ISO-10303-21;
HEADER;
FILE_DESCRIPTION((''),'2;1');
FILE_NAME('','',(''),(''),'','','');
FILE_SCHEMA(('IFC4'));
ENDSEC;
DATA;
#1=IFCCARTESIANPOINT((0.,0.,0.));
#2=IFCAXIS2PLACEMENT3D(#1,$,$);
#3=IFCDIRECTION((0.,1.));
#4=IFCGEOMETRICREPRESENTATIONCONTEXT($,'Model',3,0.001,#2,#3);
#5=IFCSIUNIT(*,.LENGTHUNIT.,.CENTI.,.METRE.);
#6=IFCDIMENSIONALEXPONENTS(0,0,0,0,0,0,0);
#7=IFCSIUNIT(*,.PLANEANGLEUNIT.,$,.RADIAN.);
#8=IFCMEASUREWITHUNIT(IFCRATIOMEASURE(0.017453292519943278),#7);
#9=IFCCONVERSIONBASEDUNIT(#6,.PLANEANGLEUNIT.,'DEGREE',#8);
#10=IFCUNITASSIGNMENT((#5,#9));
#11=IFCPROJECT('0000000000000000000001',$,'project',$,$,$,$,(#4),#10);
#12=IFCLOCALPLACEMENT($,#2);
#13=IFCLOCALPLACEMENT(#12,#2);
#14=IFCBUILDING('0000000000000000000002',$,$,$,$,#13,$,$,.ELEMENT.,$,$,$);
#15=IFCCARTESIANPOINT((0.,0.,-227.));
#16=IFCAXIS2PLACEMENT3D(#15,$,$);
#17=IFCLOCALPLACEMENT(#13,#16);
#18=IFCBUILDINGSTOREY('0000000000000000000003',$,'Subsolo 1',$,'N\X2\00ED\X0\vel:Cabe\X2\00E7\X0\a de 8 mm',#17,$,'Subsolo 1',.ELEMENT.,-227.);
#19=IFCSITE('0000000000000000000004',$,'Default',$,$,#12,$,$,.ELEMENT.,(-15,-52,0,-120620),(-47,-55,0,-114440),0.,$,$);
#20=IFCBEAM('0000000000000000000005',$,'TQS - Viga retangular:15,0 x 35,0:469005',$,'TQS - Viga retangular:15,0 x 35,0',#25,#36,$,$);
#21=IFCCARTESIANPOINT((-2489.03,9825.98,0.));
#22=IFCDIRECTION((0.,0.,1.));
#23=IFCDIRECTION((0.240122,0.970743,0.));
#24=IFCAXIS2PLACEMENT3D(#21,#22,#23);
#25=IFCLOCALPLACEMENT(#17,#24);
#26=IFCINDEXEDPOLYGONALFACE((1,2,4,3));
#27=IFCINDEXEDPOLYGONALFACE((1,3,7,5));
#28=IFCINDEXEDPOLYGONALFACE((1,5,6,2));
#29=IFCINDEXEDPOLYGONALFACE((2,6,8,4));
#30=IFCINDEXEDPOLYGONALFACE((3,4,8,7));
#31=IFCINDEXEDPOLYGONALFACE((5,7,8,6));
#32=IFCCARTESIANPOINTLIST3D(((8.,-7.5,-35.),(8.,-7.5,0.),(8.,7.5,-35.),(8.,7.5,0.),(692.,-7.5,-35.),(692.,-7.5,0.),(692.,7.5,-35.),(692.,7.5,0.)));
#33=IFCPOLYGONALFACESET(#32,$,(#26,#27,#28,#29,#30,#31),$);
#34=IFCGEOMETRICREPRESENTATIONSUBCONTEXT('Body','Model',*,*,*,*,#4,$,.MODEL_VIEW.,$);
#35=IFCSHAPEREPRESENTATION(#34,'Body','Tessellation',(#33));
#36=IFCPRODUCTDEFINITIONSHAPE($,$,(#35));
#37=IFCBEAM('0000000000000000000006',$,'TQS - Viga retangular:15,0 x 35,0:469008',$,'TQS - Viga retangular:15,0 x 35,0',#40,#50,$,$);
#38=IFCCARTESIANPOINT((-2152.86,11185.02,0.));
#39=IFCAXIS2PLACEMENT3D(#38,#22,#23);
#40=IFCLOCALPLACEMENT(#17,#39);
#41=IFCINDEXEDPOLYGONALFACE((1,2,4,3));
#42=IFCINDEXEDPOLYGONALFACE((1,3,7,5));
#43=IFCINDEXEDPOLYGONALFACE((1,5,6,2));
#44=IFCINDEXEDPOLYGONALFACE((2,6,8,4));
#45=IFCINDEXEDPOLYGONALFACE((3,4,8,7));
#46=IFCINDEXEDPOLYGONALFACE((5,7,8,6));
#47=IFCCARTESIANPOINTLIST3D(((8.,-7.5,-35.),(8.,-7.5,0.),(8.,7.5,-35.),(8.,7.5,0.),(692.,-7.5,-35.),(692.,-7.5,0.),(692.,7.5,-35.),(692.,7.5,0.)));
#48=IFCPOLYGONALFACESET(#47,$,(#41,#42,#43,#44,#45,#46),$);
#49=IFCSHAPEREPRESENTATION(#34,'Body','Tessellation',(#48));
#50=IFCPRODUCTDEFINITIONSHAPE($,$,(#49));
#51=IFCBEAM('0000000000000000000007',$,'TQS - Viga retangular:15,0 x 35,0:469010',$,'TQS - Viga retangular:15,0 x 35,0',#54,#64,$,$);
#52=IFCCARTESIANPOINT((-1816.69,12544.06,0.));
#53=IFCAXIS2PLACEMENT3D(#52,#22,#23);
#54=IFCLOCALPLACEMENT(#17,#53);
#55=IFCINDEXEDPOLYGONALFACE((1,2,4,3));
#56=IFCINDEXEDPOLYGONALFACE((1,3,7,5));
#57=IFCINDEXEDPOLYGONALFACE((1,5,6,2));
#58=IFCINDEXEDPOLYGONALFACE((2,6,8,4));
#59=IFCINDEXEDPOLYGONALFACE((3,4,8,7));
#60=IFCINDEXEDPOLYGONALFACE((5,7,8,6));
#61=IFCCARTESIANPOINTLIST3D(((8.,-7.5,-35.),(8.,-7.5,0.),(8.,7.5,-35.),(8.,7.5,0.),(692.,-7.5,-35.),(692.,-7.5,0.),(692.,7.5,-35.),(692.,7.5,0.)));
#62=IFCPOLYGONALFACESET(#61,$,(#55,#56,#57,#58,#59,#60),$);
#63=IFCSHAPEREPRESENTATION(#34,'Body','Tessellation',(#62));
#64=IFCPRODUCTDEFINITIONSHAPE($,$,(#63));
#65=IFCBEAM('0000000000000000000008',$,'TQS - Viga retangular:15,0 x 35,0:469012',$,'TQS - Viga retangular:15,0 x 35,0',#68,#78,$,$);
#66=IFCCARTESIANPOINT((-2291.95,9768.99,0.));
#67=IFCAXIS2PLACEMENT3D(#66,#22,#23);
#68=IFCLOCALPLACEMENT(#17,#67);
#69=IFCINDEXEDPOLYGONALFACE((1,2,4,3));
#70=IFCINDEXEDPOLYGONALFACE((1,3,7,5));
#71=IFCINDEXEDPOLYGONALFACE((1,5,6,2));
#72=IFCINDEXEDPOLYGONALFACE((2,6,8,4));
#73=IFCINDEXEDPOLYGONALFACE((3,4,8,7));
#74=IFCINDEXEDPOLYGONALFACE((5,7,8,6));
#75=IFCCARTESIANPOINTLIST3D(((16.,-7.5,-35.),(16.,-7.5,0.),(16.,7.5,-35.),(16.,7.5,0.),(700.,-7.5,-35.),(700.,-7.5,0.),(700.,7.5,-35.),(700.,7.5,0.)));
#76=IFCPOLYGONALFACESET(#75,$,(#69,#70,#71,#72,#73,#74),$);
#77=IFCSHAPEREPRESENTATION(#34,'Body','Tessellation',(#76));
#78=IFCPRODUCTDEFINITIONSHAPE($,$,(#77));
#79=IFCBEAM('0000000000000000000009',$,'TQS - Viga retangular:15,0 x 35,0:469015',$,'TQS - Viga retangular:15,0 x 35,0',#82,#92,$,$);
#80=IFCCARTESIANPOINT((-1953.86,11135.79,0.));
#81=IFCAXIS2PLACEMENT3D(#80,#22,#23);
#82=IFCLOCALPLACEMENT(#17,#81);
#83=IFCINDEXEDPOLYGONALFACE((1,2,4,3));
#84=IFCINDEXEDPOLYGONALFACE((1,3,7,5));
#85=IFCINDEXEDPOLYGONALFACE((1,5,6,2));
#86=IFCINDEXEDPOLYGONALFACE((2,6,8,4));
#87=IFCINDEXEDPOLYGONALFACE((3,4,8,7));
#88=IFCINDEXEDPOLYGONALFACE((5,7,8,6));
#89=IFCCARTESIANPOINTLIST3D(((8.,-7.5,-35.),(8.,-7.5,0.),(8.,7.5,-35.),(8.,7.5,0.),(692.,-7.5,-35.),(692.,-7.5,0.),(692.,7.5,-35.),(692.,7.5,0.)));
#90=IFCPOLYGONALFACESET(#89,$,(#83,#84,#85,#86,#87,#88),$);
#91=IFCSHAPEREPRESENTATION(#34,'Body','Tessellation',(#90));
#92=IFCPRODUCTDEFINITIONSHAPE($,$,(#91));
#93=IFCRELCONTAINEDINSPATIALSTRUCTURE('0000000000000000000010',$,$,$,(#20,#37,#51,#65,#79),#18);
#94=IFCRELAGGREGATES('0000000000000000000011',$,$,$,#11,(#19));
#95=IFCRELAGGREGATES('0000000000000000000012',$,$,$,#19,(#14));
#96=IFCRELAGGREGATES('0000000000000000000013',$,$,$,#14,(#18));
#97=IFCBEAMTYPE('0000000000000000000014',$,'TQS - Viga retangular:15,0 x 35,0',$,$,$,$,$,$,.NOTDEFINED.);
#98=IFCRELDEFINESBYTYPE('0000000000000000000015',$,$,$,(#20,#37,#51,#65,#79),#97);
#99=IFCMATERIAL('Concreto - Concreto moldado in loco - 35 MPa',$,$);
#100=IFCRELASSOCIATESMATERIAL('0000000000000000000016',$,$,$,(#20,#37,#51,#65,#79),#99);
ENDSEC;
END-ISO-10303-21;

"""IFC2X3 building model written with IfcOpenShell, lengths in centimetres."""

from ifc_helpers import new_model, entity, si_unit, converted_unit, direction, frame, frame_2d, origin, place, context, subcontext, project, spatial, rectangle, extrude, material, type_object, element, save


model = new_model("IFC2X3")

# Units and contexts
model_context = context("Model", 3, precision=0.001, world=origin(), true_north=direction((0.0, 1.0)))
body_context = subcontext(model_context, "Body", "Model", "MODEL_VIEW")
ifc_project = project(units=[si_unit("LENGTHUNIT", "METRE", prefix="CENTI"), converted_unit("PLANEANGLEUNIT", "DEGREE", entity("IfcRatioMeasure", 0.017453292519943278), si_unit("PLANEANGLEUNIT", "RADIAN"), dimensions=[0, 0, 0, 0, 0, 0, 0])], contexts=[model_context])

# Site, building, storey
site_placement = place(None, origin())
site = spatial("IfcSite", under=ifc_project, at=site_placement, Name="Default", CompositionType="ELEMENT", RefLatitude=(-15, -52, 0, -120620), RefLongitude=(-47, -55, 0, -114440), RefElevation=0.0)
building_placement = place(site_placement, origin())
building = spatial("IfcBuilding", under=site, at=building_placement, CompositionType="ELEMENT")
storey_placement = place(building_placement, frame((0.0, 0.0, -227.0)))
storey = spatial("IfcBuildingStorey", under=building, at=storey_placement, Name="Subsolo 1", ObjectType="Nível:Cabeça de 8 mm", LongName="Subsolo 1", CompositionType="ELEMENT", Elevation=-227.0)

# Shared definitions
ifc_material = material(Name="Concreto - Concreto moldado in loco - 35 MPa")

# Beams
beam_type_1 = type_object("IfcBeamType", Name="TQS - Viga retangular:15,0 x 35,0", PredefinedType="NOTDEFINED")
beam_1_placement = place(storey_placement, frame((-2489.03, 9825.98, 0.0), z_axis=(0.0, 0.0, 1.0), x_axis=(0.240122, 0.970743, 0.0)))
element("IfcBeam", 1, at=beam_1_placement, inside=storey, type_object=beam_type_1, material=ifc_material, Name="TQS - Viga retangular:15,0 x 35,0:469005", ObjectType="TQS - Viga retangular:15,0 x 35,0", context=body_context, shape_type="SweptSolid", body=[
    extrude(rectangle(XDim=35.0, YDim=15.0, at=frame_2d((0.0, 0.0), x_axis=(1.0, 0.0))), frame((8.0, 0.0, -17.5), z_axis=(1.0, 0.0, 0.0), x_axis=(0.0, 0.0, -1.0)), (0.0, 0.0, 1.0), 684.0),
])
beam_2_placement = place(storey_placement, frame((-2152.86, 11185.02, 0.0), z_axis=(0.0, 0.0, 1.0), x_axis=(0.240122, 0.970743, 0.0)))
element("IfcBeam", 2, at=beam_2_placement, inside=storey, type_object=beam_type_1, material=ifc_material, Name="TQS - Viga retangular:15,0 x 35,0:469008", ObjectType="TQS - Viga retangular:15,0 x 35,0", context=body_context, shape_type="SweptSolid", body=[
    extrude(rectangle(XDim=35.0, YDim=15.0, at=frame_2d((0.0, 0.0), x_axis=(1.0, 0.0))), frame((8.0, 0.0, -17.5), z_axis=(1.0, 0.0, 0.0), x_axis=(0.0, 0.0, -1.0)), (0.0, 0.0, 1.0), 684.0),
])
beam_3_placement = place(storey_placement, frame((-1816.69, 12544.06, 0.0), z_axis=(0.0, 0.0, 1.0), x_axis=(0.240122, 0.970743, 0.0)))
element("IfcBeam", 3, at=beam_3_placement, inside=storey, type_object=beam_type_1, material=ifc_material, Name="TQS - Viga retangular:15,0 x 35,0:469010", ObjectType="TQS - Viga retangular:15,0 x 35,0", context=body_context, shape_type="SweptSolid", body=[
    extrude(rectangle(XDim=35.0, YDim=15.0, at=frame_2d((0.0, 0.0), x_axis=(1.0, 0.0))), frame((8.0, 0.0, -17.5), z_axis=(1.0, 0.0, 0.0), x_axis=(0.0, 0.0, -1.0)), (0.0, 0.0, 1.0), 684.0),
])
beam_4_placement = place(storey_placement, frame((-2291.95, 9768.99, 0.0), z_axis=(0.0, 0.0, 1.0), x_axis=(0.240122, 0.970743, 0.0)))
element("IfcBeam", 4, at=beam_4_placement, inside=storey, type_object=beam_type_1, material=ifc_material, Name="TQS - Viga retangular:15,0 x 35,0:469012", ObjectType="TQS - Viga retangular:15,0 x 35,0", context=body_context, shape_type="SweptSolid", body=[
    extrude(rectangle(XDim=35.0, YDim=15.0, at=frame_2d((0.0, 0.0), x_axis=(1.0, 0.0))), frame((16.0, 0.0, -17.5), z_axis=(1.0, 0.0, 0.0), x_axis=(0.0, 0.0, -1.0)), (0.0, 0.0, 1.0), 684.0),
])
beam_5_placement = place(storey_placement, frame((-1953.86, 11135.79, 0.0), z_axis=(0.0, 0.0, 1.0), x_axis=(0.240122, 0.970743, 0.0)))
element("IfcBeam", 5, at=beam_5_placement, inside=storey, type_object=beam_type_1, material=ifc_material, Name="TQS - Viga retangular:15,0 x 35,0:469015", ObjectType="TQS - Viga retangular:15,0 x 35,0", context=body_context, shape_type="SweptSolid", body=[
    extrude(rectangle(XDim=35.0, YDim=15.0, at=frame_2d((0.0, 0.0), x_axis=(1.0, 0.0))), frame((8.0, 0.0, -17.5), z_axis=(1.0, 0.0, 0.0), x_axis=(0.0, 0.0, -1.0)), (0.0, 0.0, 1.0), 684.0),
])

save(model, "model.ifc")
